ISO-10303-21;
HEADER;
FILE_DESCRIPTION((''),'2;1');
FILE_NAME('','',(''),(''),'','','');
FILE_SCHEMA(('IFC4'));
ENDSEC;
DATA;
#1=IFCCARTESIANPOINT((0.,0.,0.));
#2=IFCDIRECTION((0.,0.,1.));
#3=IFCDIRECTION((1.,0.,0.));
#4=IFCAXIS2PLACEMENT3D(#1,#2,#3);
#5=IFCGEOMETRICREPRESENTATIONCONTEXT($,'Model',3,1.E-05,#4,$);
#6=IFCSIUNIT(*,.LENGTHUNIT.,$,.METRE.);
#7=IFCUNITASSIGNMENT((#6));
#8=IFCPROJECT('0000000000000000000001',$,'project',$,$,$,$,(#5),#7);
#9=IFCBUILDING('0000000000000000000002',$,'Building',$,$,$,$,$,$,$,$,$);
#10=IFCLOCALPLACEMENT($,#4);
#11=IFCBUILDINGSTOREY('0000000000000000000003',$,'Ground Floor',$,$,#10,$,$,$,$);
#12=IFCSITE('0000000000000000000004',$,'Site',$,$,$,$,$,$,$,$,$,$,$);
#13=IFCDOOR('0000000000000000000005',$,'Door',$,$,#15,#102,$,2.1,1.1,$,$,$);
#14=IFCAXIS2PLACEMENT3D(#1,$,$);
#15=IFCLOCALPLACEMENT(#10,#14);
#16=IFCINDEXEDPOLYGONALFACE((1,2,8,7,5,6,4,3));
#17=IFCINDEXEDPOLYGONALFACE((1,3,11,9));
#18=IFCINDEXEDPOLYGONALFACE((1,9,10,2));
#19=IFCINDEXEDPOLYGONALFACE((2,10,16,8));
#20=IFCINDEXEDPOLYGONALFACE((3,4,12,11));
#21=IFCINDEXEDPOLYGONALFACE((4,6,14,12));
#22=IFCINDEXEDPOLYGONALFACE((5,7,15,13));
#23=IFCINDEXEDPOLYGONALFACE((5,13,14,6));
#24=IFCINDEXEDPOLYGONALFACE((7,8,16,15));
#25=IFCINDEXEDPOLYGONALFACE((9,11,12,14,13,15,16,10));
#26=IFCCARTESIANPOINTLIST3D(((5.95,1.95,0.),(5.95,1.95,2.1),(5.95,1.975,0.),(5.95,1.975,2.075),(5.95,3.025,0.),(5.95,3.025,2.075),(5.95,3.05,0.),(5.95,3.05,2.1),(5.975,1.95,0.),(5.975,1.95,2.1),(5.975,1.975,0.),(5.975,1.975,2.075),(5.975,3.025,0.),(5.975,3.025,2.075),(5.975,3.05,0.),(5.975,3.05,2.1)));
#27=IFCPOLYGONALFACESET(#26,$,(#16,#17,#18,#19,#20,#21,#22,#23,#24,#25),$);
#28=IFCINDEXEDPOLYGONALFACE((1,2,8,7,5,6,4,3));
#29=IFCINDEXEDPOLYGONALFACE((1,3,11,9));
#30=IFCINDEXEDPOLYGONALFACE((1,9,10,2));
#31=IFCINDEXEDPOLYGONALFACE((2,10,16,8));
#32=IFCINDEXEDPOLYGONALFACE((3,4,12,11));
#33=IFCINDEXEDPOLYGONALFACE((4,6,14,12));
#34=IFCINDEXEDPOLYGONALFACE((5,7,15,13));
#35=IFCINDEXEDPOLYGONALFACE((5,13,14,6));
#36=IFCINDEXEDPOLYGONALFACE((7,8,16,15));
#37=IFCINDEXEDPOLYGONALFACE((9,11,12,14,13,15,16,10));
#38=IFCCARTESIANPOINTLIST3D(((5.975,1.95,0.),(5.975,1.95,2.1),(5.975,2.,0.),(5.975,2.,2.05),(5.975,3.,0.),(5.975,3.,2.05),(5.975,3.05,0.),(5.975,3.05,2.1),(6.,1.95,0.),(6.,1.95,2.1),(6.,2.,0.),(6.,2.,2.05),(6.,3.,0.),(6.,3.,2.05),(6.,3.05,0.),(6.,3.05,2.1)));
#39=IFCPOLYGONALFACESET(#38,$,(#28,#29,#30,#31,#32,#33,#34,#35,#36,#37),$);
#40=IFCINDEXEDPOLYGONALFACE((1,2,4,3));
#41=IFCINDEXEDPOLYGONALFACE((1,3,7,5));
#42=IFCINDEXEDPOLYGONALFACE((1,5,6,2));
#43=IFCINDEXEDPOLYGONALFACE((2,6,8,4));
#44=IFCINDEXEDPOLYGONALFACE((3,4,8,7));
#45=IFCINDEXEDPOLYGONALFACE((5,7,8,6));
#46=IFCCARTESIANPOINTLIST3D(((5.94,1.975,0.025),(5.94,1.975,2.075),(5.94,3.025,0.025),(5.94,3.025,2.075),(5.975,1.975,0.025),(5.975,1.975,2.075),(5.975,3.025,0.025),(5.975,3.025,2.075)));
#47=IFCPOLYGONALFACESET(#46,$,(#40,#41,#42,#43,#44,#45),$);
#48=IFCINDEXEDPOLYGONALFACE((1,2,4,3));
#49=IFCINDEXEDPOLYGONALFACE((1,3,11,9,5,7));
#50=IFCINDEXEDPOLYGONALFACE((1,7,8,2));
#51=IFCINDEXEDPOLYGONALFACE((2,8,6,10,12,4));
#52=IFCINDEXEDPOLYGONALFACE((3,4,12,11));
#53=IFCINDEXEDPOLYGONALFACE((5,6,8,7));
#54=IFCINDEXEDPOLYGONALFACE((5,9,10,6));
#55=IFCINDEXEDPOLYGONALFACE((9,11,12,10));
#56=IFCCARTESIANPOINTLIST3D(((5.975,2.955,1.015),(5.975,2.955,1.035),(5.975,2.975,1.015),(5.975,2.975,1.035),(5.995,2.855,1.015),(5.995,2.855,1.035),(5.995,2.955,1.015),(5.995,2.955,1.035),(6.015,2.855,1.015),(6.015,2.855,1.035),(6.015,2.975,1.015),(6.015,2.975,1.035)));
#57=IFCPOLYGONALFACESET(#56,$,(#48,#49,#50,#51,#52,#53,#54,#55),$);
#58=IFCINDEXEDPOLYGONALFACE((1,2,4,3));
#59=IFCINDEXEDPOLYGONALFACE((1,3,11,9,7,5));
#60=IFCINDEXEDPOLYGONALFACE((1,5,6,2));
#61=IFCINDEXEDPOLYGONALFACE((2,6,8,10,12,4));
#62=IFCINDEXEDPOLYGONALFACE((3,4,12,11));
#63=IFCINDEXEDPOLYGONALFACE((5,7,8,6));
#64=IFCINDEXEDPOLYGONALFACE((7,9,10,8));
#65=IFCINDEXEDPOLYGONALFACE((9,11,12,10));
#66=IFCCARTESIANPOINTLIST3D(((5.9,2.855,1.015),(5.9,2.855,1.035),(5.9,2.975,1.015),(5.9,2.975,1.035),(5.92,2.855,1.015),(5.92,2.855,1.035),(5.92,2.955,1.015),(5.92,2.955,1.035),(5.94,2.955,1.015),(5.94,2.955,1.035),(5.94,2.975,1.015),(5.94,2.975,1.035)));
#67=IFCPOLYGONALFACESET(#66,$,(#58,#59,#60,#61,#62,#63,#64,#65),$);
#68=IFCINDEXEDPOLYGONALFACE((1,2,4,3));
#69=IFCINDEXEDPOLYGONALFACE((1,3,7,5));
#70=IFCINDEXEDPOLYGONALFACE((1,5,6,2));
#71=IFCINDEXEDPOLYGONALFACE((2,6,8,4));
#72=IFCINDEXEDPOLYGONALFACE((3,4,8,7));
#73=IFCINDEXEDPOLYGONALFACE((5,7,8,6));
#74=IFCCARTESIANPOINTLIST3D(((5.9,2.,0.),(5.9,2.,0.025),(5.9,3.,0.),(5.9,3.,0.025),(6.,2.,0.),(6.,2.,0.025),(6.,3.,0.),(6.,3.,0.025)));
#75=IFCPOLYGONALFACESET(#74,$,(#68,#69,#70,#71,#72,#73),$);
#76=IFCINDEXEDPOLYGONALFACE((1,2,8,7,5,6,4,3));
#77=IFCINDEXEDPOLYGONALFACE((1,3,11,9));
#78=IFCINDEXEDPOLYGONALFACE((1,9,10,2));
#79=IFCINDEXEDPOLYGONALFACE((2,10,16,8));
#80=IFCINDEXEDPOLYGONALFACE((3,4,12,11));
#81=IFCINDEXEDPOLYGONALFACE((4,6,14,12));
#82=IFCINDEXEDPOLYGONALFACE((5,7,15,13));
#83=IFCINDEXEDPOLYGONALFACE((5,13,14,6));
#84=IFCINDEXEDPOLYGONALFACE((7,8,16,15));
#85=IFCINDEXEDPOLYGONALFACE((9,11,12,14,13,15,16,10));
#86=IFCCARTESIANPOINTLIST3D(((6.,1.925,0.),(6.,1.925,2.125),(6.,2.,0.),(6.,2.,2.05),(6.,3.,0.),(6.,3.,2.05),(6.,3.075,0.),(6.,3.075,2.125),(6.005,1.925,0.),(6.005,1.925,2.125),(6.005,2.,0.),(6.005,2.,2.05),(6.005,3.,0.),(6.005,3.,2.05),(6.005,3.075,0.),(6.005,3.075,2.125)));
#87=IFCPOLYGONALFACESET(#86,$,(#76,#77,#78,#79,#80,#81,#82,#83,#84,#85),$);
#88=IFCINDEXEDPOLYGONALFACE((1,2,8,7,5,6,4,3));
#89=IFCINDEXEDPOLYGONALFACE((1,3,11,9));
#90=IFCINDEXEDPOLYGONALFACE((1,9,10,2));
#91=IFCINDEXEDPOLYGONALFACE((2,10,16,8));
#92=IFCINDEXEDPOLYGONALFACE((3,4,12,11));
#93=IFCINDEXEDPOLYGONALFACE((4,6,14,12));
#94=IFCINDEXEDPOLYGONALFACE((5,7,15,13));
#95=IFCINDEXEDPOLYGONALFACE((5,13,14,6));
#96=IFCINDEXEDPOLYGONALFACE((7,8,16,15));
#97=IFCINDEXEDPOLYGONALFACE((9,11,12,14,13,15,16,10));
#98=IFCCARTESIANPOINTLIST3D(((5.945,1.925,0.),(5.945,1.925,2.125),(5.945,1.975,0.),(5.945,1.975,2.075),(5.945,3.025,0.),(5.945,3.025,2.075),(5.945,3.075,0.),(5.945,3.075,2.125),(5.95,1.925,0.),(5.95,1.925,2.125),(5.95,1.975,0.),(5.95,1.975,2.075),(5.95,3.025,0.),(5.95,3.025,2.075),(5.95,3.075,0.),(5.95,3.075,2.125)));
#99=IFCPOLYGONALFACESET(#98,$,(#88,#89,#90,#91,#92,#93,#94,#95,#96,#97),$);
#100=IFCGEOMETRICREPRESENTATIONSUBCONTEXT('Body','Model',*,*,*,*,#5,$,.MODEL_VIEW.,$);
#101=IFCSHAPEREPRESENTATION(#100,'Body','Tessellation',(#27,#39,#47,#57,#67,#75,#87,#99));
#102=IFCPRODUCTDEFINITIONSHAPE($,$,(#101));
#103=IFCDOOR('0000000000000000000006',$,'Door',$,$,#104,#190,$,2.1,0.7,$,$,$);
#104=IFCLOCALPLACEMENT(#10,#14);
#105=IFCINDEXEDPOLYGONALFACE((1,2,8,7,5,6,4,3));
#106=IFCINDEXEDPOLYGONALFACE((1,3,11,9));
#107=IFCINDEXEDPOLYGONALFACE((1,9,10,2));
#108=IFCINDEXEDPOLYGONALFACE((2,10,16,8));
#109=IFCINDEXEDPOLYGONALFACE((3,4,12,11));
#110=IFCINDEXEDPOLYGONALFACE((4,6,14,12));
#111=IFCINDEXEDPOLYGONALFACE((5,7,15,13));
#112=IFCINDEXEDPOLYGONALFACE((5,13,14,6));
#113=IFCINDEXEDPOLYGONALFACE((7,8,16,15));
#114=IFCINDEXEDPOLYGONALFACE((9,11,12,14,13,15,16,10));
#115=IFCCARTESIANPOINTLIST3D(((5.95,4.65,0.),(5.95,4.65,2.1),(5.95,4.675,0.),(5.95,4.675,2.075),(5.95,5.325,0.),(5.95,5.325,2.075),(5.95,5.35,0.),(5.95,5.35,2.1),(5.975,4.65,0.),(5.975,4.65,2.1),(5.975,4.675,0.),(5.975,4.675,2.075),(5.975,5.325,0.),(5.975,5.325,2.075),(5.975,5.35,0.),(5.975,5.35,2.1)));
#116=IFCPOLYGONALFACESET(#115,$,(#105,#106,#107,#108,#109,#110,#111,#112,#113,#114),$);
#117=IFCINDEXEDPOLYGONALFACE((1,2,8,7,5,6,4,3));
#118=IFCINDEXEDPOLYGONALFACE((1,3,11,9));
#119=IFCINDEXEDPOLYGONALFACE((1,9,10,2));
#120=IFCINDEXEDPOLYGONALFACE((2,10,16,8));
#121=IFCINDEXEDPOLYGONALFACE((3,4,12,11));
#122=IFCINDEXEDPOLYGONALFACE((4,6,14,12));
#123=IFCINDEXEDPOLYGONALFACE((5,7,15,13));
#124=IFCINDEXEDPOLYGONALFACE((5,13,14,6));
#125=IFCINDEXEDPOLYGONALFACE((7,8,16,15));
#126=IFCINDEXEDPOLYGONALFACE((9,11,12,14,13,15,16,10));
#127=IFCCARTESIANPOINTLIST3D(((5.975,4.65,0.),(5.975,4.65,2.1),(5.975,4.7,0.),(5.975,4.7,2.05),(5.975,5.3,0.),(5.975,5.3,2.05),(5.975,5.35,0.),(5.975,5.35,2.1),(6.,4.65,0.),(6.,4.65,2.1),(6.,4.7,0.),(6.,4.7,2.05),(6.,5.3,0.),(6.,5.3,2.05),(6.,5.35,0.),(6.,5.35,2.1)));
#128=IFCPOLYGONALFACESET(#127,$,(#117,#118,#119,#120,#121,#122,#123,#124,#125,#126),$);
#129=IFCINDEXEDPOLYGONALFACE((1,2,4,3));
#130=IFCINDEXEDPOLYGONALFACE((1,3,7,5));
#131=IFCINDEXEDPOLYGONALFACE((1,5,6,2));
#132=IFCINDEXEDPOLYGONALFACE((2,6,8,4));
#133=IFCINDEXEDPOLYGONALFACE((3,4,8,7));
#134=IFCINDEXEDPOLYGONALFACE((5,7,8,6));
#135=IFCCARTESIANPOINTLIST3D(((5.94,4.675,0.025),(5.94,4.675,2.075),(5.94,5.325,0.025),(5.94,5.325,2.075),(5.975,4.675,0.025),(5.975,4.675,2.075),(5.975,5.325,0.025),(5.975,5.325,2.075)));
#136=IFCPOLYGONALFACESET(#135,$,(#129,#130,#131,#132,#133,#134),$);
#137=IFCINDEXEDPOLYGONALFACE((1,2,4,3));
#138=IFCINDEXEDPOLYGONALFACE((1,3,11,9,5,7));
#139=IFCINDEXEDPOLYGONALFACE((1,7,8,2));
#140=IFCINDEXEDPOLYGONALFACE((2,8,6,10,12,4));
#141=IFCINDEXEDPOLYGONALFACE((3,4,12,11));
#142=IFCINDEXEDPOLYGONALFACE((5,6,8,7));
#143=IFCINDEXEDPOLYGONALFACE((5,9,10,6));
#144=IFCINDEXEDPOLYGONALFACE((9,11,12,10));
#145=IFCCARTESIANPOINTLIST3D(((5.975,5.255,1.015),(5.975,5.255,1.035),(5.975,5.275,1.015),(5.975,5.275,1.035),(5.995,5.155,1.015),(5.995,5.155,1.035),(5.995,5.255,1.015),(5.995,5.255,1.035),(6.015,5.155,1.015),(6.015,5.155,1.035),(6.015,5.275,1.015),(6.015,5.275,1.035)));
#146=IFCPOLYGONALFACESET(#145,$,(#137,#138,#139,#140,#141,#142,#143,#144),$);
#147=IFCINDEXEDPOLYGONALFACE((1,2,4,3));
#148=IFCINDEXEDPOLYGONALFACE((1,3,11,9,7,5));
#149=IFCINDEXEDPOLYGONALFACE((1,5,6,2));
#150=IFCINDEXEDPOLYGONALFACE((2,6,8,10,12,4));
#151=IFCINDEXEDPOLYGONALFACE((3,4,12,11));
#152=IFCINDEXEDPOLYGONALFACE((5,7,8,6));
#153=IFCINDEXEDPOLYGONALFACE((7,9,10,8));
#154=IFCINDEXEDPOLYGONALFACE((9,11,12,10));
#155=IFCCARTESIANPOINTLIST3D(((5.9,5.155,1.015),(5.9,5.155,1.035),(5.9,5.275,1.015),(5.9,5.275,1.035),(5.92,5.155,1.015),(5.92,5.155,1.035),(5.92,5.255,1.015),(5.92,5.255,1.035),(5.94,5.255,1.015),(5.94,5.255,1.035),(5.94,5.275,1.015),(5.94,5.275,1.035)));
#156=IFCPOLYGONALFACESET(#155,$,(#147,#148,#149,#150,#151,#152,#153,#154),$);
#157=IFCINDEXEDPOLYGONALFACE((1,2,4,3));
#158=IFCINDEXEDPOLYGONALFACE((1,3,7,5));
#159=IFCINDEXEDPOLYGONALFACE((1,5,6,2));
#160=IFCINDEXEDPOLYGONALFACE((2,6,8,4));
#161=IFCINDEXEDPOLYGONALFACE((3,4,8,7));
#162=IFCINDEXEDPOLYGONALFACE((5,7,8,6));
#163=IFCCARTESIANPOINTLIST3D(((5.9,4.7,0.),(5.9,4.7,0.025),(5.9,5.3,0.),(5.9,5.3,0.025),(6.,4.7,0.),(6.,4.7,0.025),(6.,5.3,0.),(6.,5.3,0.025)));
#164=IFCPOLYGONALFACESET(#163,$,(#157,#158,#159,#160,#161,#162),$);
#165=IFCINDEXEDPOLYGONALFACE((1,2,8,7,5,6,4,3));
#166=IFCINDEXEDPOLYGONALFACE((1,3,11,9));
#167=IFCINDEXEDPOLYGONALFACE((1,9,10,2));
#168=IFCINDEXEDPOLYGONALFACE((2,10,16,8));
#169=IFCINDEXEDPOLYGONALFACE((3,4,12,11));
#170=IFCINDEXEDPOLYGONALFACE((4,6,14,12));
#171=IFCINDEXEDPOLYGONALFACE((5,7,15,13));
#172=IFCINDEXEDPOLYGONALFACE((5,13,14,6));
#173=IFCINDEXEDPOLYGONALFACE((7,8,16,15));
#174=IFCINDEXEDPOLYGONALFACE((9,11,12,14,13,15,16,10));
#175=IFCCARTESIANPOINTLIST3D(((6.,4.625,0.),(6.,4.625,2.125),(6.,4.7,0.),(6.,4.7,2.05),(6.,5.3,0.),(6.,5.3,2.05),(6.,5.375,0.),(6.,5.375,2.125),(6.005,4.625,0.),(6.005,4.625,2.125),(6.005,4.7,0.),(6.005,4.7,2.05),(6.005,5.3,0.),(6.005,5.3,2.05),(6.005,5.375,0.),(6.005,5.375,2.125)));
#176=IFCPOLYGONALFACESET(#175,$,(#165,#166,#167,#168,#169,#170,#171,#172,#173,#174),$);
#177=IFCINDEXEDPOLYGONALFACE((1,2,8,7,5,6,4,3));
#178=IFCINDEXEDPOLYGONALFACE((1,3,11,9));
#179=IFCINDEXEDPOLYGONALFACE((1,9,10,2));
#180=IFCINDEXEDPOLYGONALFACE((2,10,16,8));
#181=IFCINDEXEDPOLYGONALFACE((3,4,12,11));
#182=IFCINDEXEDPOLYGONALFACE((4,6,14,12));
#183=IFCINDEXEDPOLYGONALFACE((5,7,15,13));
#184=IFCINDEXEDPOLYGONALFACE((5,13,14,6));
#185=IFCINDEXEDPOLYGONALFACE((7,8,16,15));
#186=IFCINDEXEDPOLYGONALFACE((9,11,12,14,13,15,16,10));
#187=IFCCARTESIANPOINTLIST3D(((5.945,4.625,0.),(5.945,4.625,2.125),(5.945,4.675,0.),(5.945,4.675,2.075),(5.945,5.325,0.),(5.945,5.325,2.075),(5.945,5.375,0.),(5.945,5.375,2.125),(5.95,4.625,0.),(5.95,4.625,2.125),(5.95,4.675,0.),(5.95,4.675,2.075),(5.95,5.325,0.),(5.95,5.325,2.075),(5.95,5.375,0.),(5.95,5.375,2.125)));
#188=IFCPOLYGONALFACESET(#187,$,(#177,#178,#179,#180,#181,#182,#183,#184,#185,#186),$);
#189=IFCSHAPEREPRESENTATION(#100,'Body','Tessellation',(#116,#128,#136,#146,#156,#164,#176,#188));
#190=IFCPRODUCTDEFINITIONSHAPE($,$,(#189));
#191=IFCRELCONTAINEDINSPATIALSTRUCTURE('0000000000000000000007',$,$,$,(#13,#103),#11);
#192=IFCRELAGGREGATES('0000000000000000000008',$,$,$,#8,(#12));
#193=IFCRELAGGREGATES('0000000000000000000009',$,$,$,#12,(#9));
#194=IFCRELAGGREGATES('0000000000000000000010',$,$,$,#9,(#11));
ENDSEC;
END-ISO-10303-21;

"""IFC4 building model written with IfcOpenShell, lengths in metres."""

from ifc_helpers import new_model, si_unit, frame, origin_with_axes, place, context, subcontext, project, spatial, line, indexed_curve, outline, extrude, element, save


model = new_model("IFC4")

# Units and contexts
model_context = context("Model", 3, precision=1e-05, world=origin_with_axes())
body_context = subcontext(model_context, "Body", "Model", "MODEL_VIEW")
ifc_project = project(units=[si_unit("LENGTHUNIT", "METRE")], contexts=[model_context])

# Site, building, storey
site = spatial("IfcSite", under=ifc_project, Name="Site")
building = spatial("IfcBuilding", under=site, Name="Building")
storey_placement = place(None, origin_with_axes())
storey = spatial("IfcBuildingStorey", under=building, at=storey_placement, Name="Ground Floor")

# Doors
door_1_placement = place(storey_placement, frame((6.0, 1.95, 0.0), z_axis=(0.0, 0.0, 1.0), x_axis=(0.0, 1.0, 0.0)))
element("IfcDoor", 1, at=door_1_placement, inside=storey, Name="Door", OverallHeight=2.1, OverallWidth=1.1, context=body_context, shape_type="SweptSolid", body=[
    extrude(outline(indexed_curve([(0.0, 0.0), (0.0, 2.1), (1.1, 2.1), (1.1, 0.0), (1.075, 0.0), (1.075, 2.075), (0.025, 2.075), (0.025, 0.0)], segments=[line(1, 2, 3, 4, 5, 6, 7, 8, 1)])), frame((0.0, 0.025, 0.0), z_axis=(0.0, -1.0, 0.0), x_axis=(1.0, 0.0, 0.0)), (0.0, 0.0, -1.0), 0.025),
    extrude(outline(indexed_curve([(0.0, 0.0), (0.0, 2.1), (1.1, 2.1), (1.1, 0.0), (1.05, 0.0), (1.05, 2.05), (0.05, 2.05), (0.05, 0.0)], segments=[line(1, 2, 3, 4, 5, 6, 7, 8, 1)])), frame((0.0, 0.0, 0.0), z_axis=(0.0, -1.0, 0.0), x_axis=(1.0, 0.0, 0.0)), (0.0, 0.0, -1.0), 0.025),
    extrude(outline(indexed_curve([(0.0, 0.0), (1.05, 0.0), (1.05, 0.035), (0.0, 0.035)], segments=[line(1, 2, 3, 4, 1)])), frame((0.025, 0.025, 0.025), z_axis=(0.0, 0.0, 1.0), x_axis=(1.0, 0.0, 0.0)), (0.0, 0.0, 1.0), 2.05),
    extrude(outline(indexed_curve([(0.0, 0.0), (0.0, -0.04), (-0.12, -0.04), (-0.12, -0.02), (-0.02, -0.02), (-0.02, 0.0)], segments=[line(1, 2, 3, 4, 5, 6, 1)])), frame((1.025, 0.025, 1.015), z_axis=(0.0, 0.0, 1.0), x_axis=(1.0, 0.0, 0.0)), (0.0, 0.0, 1.0), 0.02),
    extrude(outline(indexed_curve([(0.0, 0.0), (0.0, 0.04), (-0.12, 0.04), (-0.12, 0.02), (-0.02, 0.02), (-0.02, 0.0)], segments=[line(1, 2, 3, 4, 5, 6, 1)])), frame((1.025, 0.06, 1.015), z_axis=(0.0, 0.0, 1.0), x_axis=(1.0, 0.0, 0.0)), (0.0, 0.0, 1.0), 0.02),
    extrude(outline(indexed_curve([(0.0, 0.0), (1.0, 0.0), (1.0, 0.1), (0.0, 0.1)], segments=[line(1, 2, 3, 4, 1)])), frame((0.05, 0.0, 0.0), z_axis=(0.0, 0.0, 1.0), x_axis=(1.0, 0.0, 0.0)), (0.0, 0.0, 1.0), 0.025),
    extrude(outline(indexed_curve([(0.0, 0.0), (0.0, 2.125), (1.15, 2.125), (1.15, 0.0), (1.075, 0.0), (1.075, 2.05), (0.075, 2.05), (0.075, 0.0)], segments=[line(1, 2, 3, 4, 5, 6, 7, 8, 1)])), frame((-0.025, -0.005, 0.0), z_axis=(0.0, -1.0, 0.0), x_axis=(1.0, 0.0, 0.0)), (0.0, 0.0, -1.0), 0.005),
    extrude(outline(indexed_curve([(0.0, 0.0), (0.0, 2.125), (1.15, 2.125), (1.15, 0.0), (1.1, 0.0), (1.1, 2.075), (0.05, 2.075), (0.05, 0.0)], segments=[line(1, 2, 3, 4, 5, 6, 7, 8, 1)])), frame((-0.025, 0.05, 0.0), z_axis=(0.0, -1.0, 0.0), x_axis=(1.0, 0.0, 0.0)), (0.0, 0.0, -1.0), 0.005),
])
door_2_placement = place(storey_placement, frame((6.0, 4.65, 0.0), z_axis=(0.0, 0.0, 1.0), x_axis=(0.0, 1.0, 0.0)))
element("IfcDoor", 2, at=door_2_placement, inside=storey, Name="Door", OverallHeight=2.1, OverallWidth=0.7, context=body_context, shape_type="SweptSolid", body=[
    extrude(outline(indexed_curve([(0.0, 0.0), (0.0, 2.1), (0.7, 2.1), (0.7, 0.0), (0.675, 0.0), (0.675, 2.075), (0.025, 2.075), (0.025, 0.0)], segments=[line(1, 2, 3, 4, 5, 6, 7, 8, 1)])), frame((0.0, 0.025, 0.0), z_axis=(0.0, -1.0, 0.0), x_axis=(1.0, 0.0, 0.0)), (0.0, 0.0, -1.0), 0.025),
    extrude(outline(indexed_curve([(0.0, 0.0), (0.0, 2.1), (0.7, 2.1), (0.7, 0.0), (0.65, 0.0), (0.65, 2.05), (0.05, 2.05), (0.05, 0.0)], segments=[line(1, 2, 3, 4, 5, 6, 7, 8, 1)])), frame((0.0, 0.0, 0.0), z_axis=(0.0, -1.0, 0.0), x_axis=(1.0, 0.0, 0.0)), (0.0, 0.0, -1.0), 0.025),
    extrude(outline(indexed_curve([(0.0, 0.0), (0.65, 0.0), (0.65, 0.035), (0.0, 0.035)], segments=[line(1, 2, 3, 4, 1)])), frame((0.025, 0.025, 0.025), z_axis=(0.0, 0.0, 1.0), x_axis=(1.0, 0.0, 0.0)), (0.0, 0.0, 1.0), 2.05),
    extrude(outline(indexed_curve([(0.0, 0.0), (0.0, -0.04), (-0.12, -0.04), (-0.12, -0.02), (-0.02, -0.02), (-0.02, 0.0)], segments=[line(1, 2, 3, 4, 5, 6, 1)])), frame((0.625, 0.025, 1.015), z_axis=(0.0, 0.0, 1.0), x_axis=(1.0, 0.0, 0.0)), (0.0, 0.0, 1.0), 0.02),
    extrude(outline(indexed_curve([(0.0, 0.0), (0.0, 0.04), (-0.12, 0.04), (-0.12, 0.02), (-0.02, 0.02), (-0.02, 0.0)], segments=[line(1, 2, 3, 4, 5, 6, 1)])), frame((0.625, 0.06, 1.015), z_axis=(0.0, 0.0, 1.0), x_axis=(1.0, 0.0, 0.0)), (0.0, 0.0, 1.0), 0.02),
    extrude(outline(indexed_curve([(0.0, 0.0), (0.6, 0.0), (0.6, 0.1), (0.0, 0.1)], segments=[line(1, 2, 3, 4, 1)])), frame((0.05, 0.0, 0.0), z_axis=(0.0, 0.0, 1.0), x_axis=(1.0, 0.0, 0.0)), (0.0, 0.0, 1.0), 0.025),
    extrude(outline(indexed_curve([(0.0, 0.0), (0.0, 2.125), (0.75, 2.125), (0.75, 0.0), (0.675, 0.0), (0.675, 2.05), (0.075, 2.05), (0.075, 0.0)], segments=[line(1, 2, 3, 4, 5, 6, 7, 8, 1)])), frame((-0.025, -0.005, 0.0), z_axis=(0.0, -1.0, 0.0), x_axis=(1.0, 0.0, 0.0)), (0.0, 0.0, -1.0), 0.005),
    extrude(outline(indexed_curve([(0.0, 0.0), (0.0, 2.125), (0.75, 2.125), (0.75, 0.0), (0.7, 0.0), (0.7, 2.075), (0.05, 2.075), (0.05, 0.0)], segments=[line(1, 2, 3, 4, 5, 6, 7, 8, 1)])), frame((-0.025, 0.05, 0.0), z_axis=(0.0, -1.0, 0.0), x_axis=(1.0, 0.0, 0.0)), (0.0, 0.0, -1.0), 0.005),
])

save(model, "model.ifc")
